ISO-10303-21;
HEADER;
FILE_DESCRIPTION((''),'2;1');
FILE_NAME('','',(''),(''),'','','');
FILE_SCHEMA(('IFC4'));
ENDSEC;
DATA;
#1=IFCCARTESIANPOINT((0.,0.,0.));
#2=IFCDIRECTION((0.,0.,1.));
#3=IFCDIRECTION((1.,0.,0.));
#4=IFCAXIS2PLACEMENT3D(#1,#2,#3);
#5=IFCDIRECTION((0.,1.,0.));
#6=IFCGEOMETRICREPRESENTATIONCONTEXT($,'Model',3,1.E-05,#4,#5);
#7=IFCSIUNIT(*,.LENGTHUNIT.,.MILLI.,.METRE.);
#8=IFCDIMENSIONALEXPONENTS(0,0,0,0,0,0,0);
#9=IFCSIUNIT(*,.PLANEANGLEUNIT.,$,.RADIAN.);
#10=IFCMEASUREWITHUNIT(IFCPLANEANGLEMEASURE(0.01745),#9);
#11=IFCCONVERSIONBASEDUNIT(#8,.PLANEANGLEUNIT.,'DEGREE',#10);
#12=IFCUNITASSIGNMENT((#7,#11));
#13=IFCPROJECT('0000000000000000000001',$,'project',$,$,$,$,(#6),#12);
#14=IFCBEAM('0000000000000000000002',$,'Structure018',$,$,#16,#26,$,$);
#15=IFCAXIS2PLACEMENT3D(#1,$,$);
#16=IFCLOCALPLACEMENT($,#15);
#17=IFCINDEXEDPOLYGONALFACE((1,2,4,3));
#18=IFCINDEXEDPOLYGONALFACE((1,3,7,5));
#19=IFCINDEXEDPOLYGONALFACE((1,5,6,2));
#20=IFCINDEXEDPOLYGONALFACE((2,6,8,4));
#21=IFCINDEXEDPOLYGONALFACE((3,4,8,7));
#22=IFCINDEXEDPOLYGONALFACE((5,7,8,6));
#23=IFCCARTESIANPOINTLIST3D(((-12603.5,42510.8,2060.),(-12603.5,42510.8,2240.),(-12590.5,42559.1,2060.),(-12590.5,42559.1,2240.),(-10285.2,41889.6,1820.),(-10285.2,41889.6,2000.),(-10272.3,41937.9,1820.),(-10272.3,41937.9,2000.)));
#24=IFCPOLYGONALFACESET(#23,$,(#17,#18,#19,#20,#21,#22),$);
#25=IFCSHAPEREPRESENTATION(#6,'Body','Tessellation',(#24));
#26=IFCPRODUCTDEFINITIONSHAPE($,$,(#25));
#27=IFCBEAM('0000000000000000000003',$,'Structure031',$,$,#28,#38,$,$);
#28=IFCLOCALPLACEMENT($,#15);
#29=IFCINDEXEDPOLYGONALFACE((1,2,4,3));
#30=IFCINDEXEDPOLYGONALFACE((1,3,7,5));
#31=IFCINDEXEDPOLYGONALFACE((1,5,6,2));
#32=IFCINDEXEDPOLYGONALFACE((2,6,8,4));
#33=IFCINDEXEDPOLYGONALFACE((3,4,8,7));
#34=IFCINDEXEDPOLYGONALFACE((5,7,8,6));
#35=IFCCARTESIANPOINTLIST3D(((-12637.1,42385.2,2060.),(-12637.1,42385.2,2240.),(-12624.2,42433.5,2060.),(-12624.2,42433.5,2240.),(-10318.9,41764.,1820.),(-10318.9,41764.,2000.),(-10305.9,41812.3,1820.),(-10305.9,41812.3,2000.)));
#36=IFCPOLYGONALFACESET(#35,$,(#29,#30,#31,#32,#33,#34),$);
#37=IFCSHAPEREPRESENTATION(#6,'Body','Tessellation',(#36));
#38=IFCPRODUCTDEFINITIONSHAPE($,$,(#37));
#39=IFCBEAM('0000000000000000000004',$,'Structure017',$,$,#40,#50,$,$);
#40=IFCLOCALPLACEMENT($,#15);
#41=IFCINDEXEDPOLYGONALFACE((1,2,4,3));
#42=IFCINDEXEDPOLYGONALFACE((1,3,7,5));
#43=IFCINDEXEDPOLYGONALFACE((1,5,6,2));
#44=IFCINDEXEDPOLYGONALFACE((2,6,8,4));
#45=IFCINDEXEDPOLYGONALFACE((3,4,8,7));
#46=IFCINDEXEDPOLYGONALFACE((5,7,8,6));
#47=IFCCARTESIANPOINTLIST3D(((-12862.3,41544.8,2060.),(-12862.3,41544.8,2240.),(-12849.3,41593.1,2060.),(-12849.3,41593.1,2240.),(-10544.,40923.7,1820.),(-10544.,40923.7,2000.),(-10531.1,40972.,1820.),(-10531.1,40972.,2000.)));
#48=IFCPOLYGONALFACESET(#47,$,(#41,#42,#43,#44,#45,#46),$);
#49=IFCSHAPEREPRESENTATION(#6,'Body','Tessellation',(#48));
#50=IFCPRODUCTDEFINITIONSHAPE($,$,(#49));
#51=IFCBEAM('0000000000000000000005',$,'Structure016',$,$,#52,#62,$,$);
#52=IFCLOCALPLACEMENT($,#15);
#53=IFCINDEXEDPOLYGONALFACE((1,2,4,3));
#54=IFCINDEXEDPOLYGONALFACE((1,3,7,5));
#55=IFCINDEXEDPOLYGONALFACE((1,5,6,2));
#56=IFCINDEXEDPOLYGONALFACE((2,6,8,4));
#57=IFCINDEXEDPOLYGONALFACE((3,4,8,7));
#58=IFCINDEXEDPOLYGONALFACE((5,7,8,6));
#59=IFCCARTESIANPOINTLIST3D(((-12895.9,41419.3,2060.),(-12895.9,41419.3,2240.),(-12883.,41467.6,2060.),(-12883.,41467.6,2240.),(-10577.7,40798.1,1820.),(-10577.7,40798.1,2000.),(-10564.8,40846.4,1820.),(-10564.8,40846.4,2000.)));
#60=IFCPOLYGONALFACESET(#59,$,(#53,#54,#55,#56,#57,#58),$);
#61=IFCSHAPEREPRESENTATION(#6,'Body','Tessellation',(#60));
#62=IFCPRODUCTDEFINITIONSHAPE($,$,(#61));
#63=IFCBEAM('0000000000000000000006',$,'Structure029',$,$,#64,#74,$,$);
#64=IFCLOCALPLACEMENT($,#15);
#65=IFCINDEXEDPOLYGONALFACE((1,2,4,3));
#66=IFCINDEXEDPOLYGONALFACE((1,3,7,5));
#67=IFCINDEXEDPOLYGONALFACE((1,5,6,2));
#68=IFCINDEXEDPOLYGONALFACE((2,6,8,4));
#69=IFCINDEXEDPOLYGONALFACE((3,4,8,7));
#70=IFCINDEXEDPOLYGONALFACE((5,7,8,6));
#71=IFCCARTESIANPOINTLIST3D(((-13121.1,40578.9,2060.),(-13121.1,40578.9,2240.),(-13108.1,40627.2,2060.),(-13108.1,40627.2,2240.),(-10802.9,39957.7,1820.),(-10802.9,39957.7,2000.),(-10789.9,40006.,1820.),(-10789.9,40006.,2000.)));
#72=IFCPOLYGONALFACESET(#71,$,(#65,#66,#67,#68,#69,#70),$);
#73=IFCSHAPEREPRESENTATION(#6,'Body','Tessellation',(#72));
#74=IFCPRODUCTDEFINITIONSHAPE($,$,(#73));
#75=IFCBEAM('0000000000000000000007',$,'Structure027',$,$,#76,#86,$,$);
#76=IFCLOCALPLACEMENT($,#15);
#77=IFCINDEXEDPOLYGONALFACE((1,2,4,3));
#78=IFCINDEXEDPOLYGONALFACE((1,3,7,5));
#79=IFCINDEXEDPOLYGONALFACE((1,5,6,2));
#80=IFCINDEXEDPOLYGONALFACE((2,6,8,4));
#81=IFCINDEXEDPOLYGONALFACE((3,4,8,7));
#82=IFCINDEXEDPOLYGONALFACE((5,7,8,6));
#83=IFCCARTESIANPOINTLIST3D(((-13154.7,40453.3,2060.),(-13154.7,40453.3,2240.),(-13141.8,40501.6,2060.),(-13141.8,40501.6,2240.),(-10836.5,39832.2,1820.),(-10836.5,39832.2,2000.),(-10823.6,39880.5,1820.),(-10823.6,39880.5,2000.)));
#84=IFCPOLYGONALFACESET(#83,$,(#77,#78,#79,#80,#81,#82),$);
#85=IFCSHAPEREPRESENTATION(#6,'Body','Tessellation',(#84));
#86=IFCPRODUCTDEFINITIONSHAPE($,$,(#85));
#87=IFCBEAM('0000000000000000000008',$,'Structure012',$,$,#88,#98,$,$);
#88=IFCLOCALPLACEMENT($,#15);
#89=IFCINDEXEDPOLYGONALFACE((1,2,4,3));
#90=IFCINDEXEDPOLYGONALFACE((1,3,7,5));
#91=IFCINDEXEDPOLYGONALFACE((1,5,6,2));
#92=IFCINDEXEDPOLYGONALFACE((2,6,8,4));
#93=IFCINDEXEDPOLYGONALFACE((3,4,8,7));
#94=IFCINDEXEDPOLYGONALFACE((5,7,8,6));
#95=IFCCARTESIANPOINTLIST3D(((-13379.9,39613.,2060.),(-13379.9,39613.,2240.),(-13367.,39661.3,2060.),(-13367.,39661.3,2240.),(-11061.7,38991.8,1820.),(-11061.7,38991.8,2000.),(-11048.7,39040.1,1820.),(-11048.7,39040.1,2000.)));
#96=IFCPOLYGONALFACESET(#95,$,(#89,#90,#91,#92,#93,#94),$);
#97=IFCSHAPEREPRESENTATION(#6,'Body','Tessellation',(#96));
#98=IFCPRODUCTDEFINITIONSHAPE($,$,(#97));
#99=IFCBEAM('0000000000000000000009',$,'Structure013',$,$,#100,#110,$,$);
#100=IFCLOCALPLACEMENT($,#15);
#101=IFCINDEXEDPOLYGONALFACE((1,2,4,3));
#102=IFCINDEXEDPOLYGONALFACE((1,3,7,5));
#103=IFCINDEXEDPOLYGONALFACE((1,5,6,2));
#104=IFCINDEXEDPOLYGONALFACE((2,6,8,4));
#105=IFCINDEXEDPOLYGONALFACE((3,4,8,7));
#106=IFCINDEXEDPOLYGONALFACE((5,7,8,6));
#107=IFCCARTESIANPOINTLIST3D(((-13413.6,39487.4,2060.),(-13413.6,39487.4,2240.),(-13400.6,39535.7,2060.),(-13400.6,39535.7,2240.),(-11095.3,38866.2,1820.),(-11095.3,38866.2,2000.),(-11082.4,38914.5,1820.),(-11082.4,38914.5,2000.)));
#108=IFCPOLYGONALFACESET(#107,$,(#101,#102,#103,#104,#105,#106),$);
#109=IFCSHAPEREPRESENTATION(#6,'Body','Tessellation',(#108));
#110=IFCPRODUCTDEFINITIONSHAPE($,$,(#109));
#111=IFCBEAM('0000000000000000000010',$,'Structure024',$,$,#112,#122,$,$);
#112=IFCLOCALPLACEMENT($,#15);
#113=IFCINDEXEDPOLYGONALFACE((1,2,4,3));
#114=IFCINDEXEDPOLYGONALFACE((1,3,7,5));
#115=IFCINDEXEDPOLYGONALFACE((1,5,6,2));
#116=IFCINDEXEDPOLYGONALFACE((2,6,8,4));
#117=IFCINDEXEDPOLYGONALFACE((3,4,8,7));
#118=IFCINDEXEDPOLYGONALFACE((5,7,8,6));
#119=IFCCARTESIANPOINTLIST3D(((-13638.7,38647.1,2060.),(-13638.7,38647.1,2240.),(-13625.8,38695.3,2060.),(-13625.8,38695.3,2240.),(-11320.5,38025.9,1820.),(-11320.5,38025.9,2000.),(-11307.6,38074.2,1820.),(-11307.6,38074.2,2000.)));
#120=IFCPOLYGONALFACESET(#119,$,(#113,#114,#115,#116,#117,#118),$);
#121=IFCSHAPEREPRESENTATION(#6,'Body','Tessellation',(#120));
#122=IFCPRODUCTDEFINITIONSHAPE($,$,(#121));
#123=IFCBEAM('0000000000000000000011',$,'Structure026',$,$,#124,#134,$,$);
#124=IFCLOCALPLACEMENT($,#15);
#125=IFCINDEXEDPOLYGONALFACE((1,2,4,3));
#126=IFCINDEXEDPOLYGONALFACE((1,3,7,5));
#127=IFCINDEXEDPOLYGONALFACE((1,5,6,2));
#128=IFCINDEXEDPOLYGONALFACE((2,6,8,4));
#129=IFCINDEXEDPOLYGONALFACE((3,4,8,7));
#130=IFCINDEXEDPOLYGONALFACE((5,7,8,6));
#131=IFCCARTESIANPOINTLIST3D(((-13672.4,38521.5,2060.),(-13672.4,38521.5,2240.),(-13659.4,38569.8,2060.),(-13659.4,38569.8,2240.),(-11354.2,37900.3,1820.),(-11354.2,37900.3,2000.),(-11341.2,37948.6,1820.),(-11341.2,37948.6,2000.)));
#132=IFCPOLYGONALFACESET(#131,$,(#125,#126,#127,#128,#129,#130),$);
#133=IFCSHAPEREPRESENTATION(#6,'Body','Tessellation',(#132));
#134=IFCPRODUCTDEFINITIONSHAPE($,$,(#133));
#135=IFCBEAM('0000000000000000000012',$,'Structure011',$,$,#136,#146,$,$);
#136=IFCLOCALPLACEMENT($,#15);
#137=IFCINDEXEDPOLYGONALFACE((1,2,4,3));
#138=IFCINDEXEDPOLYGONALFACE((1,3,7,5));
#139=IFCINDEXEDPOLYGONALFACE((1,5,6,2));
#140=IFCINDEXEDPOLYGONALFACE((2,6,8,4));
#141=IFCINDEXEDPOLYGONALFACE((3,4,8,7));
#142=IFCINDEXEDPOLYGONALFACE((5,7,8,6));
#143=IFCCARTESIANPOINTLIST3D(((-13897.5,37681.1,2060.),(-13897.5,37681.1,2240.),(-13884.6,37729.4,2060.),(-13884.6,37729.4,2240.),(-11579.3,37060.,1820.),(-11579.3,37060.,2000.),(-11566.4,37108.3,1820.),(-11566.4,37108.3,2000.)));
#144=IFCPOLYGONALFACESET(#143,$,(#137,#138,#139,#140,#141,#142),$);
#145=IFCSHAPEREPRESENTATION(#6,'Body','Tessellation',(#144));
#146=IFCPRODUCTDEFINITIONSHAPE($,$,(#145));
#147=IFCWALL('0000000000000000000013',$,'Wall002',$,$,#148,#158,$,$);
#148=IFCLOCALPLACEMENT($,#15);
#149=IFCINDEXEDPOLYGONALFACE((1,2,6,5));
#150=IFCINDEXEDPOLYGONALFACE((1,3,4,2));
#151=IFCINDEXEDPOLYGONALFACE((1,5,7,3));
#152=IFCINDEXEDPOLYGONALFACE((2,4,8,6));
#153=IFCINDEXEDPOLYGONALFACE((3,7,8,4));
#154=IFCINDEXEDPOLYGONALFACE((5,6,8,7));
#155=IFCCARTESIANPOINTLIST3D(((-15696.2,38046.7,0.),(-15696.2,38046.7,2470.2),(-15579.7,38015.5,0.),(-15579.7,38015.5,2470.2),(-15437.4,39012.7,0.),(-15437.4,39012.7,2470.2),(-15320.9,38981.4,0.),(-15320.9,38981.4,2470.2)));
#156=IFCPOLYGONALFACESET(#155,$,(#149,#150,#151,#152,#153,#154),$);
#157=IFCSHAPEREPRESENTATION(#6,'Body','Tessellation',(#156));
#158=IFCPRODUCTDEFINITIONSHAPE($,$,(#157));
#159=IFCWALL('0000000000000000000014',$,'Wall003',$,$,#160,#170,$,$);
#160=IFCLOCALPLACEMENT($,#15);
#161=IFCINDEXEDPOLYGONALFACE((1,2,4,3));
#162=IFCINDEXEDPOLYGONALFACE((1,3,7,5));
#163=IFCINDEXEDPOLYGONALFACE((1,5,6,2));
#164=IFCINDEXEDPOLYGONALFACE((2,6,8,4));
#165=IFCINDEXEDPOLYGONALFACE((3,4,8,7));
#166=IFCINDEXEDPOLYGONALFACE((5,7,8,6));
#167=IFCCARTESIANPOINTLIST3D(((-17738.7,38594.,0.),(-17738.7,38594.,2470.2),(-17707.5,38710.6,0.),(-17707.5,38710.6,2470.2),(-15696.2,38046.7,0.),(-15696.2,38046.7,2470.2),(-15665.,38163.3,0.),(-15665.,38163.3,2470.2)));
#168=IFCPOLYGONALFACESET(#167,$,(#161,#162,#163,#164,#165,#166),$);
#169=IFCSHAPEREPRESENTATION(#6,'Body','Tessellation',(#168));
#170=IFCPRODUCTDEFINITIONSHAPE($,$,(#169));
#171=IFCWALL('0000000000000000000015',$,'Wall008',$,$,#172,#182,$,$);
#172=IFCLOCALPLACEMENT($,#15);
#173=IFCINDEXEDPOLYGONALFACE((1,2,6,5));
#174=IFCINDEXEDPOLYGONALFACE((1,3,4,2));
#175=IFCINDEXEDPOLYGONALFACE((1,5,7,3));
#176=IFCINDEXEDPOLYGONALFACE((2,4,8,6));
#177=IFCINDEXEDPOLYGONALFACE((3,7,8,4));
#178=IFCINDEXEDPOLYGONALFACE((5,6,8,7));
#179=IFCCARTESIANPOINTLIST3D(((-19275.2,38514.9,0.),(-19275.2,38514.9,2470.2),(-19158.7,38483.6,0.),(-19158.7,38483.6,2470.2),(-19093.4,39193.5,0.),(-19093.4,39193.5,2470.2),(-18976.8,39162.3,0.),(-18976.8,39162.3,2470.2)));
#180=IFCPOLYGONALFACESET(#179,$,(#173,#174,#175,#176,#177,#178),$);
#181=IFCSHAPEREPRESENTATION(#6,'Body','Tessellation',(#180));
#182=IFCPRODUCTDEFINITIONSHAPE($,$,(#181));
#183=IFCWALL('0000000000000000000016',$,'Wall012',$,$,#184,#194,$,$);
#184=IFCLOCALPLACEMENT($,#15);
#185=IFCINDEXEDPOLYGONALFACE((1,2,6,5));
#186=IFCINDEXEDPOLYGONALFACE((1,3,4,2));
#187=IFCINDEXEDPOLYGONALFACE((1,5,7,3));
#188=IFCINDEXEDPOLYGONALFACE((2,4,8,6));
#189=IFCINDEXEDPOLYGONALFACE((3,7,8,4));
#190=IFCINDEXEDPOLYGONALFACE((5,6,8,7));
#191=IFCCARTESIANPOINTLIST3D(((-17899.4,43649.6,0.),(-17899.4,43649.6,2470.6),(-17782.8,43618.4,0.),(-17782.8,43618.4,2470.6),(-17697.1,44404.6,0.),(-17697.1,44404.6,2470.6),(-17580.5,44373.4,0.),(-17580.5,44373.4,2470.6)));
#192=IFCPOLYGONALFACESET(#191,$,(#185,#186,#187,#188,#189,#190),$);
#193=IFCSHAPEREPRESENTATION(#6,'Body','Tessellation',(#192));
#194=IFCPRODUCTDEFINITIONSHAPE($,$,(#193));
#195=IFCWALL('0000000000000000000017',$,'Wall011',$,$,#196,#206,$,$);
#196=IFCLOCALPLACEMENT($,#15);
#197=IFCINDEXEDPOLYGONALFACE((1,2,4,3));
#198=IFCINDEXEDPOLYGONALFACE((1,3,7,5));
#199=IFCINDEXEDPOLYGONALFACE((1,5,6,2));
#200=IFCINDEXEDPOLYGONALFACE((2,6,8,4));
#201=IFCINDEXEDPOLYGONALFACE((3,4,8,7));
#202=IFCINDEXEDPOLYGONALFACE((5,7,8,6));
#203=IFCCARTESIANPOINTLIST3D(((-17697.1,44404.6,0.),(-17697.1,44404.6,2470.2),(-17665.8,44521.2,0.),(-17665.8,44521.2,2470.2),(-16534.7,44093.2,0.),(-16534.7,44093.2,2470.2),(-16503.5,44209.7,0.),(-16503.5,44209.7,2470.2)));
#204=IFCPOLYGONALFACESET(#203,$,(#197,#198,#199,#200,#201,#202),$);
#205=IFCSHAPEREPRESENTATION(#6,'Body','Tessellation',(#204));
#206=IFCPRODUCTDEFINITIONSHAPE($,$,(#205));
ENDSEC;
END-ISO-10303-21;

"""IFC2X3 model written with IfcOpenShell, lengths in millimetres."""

from ifc_helpers import new_model, entity, si_unit, converted_unit, direction, frame, origin_with_axes, place, context, project, polyline, outline, extrude, element, save


model = new_model("IFC2X3")

# Units and contexts
model_context = context("Model", 3, precision=1e-05, world=origin_with_axes(), true_north=direction((0.0, 1.0, 0.0)))
ifc_project = project(units=[si_unit("LENGTHUNIT", "METRE", prefix="MILLI"), converted_unit("PLANEANGLEUNIT", "DEGREE", entity("IfcPlaneAngleMeasure", 0.01745), si_unit("PLANEANGLEUNIT", "RADIAN"), dimensions=[0, 0, 0, 0, 0, 0, 0])], contexts=[model_context])

# Beams
beam_1_placement = place(None, origin_with_axes())
element("IfcBeam", 1, at=beam_1_placement, Name="Structure018", context=model_context, shape_type="SweptSolid", body=[
    extrude(outline(polyline([(-90.0, -25.0), (90.0, -25.0), (90.0, 25.0), (-90.0, 25.0), (-90.0, -25.0)])), frame((-12597.0, 42534.9, 2150.0), z_axis=(0.965926, -0.258818, 0.0), x_axis=(0.0, 0.0, -1.0)), (0.099504, 0.0, 0.995037), 2412.0),
])
beam_2_placement = place(None, origin_with_axes())
element("IfcBeam", 2, at=beam_2_placement, Name="Structure031", context=model_context, shape_type="SweptSolid", body=[
    extrude(outline(polyline([(-90.0, -25.0), (90.0, -25.0), (90.0, 25.0), (-90.0, 25.0), (-90.0, -25.0)])), frame((-12630.6, 42409.3, 2150.0), z_axis=(0.965926, -0.258818, 0.0), x_axis=(0.0, 0.0, -1.0)), (0.099504, 0.0, 0.995037), 2412.0),
])
beam_3_placement = place(None, origin_with_axes())
element("IfcBeam", 3, at=beam_3_placement, Name="Structure017", context=model_context, shape_type="SweptSolid", body=[
    extrude(outline(polyline([(-90.0, -25.0), (90.0, -25.0), (90.0, 25.0), (-90.0, 25.0), (-90.0, -25.0)])), frame((-12855.8, 41569.0, 2150.0), z_axis=(0.965926, -0.258818, 0.0), x_axis=(0.0, 0.0, -1.0)), (0.099504, 0.0, 0.995037), 2412.0),
])
beam_4_placement = place(None, origin_with_axes())
element("IfcBeam", 4, at=beam_4_placement, Name="Structure016", context=model_context, shape_type="SweptSolid", body=[
    extrude(outline(polyline([(-90.0, -25.0), (90.0, -25.0), (90.0, 25.0), (-90.0, 25.0), (-90.0, -25.0)])), frame((-12889.4, 41443.4, 2150.0), z_axis=(0.965926, -0.258818, 0.0), x_axis=(0.0, 0.0, -1.0)), (0.099504, 0.0, 0.995037), 2412.0),
])
beam_5_placement = place(None, origin_with_axes())
element("IfcBeam", 5, at=beam_5_placement, Name="Structure029", context=model_context, shape_type="SweptSolid", body=[
    extrude(outline(polyline([(-90.0, -25.0), (90.0, -25.0), (90.0, 25.0), (-90.0, 25.0), (-90.0, -25.0)])), frame((-13114.6, 40603.1, 2150.0), z_axis=(0.965926, -0.258818, 0.0), x_axis=(0.0, 0.0, -1.0)), (0.099504, 0.0, 0.995037), 2412.0),
])
beam_6_placement = place(None, origin_with_axes())
element("IfcBeam", 6, at=beam_6_placement, Name="Structure027", context=model_context, shape_type="SweptSolid", body=[
    extrude(outline(polyline([(-90.0, -25.0), (90.0, -25.0), (90.0, 25.0), (-90.0, 25.0), (-90.0, -25.0)])), frame((-13148.3, 40477.5, 2150.0), z_axis=(0.965926, -0.258818, 0.0), x_axis=(0.0, 0.0, -1.0)), (0.099504, 0.0, 0.995037), 2412.0),
])
beam_7_placement = place(None, origin_with_axes())
element("IfcBeam", 7, at=beam_7_placement, Name="Structure012", context=model_context, shape_type="SweptSolid", body=[
    extrude(outline(polyline([(-90.0, -25.0), (90.0, -25.0), (90.0, 25.0), (-90.0, 25.0), (-90.0, -25.0)])), frame((-13373.4, 39637.1, 2150.0), z_axis=(0.965926, -0.258818, 0.0), x_axis=(0.0, 0.0, -1.0)), (0.099504, 0.0, 0.995037), 2412.0),
])
beam_8_placement = place(None, origin_with_axes())
element("IfcBeam", 8, at=beam_8_placement, Name="Structure013", context=model_context, shape_type="SweptSolid", body=[
    extrude(outline(polyline([(-90.0, -25.0), (90.0, -25.0), (90.0, 25.0), (-90.0, 25.0), (-90.0, -25.0)])), frame((-13407.1, 39511.6, 2150.0), z_axis=(0.965926, -0.258818, 0.0), x_axis=(0.0, 0.0, -1.0)), (0.099504, 0.0, 0.995037), 2412.0),
])
beam_9_placement = place(None, origin_with_axes())
element("IfcBeam", 9, at=beam_9_placement, Name="Structure024", context=model_context, shape_type="SweptSolid", body=[
    extrude(outline(polyline([(-90.0, -25.0), (90.0, -25.0), (90.0, 25.0), (-90.0, 25.0), (-90.0, -25.0)])), frame((-13632.3, 38671.2, 2150.0), z_axis=(0.965926, -0.258818, 0.0), x_axis=(0.0, 0.0, -1.0)), (0.099504, 0.0, 0.995037), 2412.0),
])
beam_10_placement = place(None, origin_with_axes())
element("IfcBeam", 10, at=beam_10_placement, Name="Structure026", context=model_context, shape_type="SweptSolid", body=[
    extrude(outline(polyline([(-90.0, -25.0), (90.0, -25.0), (90.0, 25.0), (-90.0, 25.0), (-90.0, -25.0)])), frame((-13665.9, 38545.6, 2150.0), z_axis=(0.965926, -0.258818, 0.0), x_axis=(0.0, 0.0, -1.0)), (0.099504, 0.0, 0.995037), 2412.0),
])
beam_11_placement = place(None, origin_with_axes())
element("IfcBeam", 11, at=beam_11_placement, Name="Structure011", context=model_context, shape_type="SweptSolid", body=[
    extrude(outline(polyline([(-90.0, -25.0), (90.0, -25.0), (90.0, 25.0), (-90.0, 25.0), (-90.0, -25.0)])), frame((-13891.1, 37705.3, 2150.0), z_axis=(0.965926, -0.258818, 0.0), x_axis=(0.0, 0.0, -1.0)), (0.099504, 0.0, 0.995037), 2412.0),
])

# Walls
wall_1_placement = place(None, origin_with_axes())
element("IfcWall", 12, at=wall_1_placement, Name="Wall002", context=model_context, shape_type="SweptSolid", body=[
    extrude(outline(polyline([(0.0, 0.0), (-120.7, 0.0), (-120.6, 1000.0), (0.0, 1000.0), (0.0, 0.0)])), frame((-15579.7, 38015.5, 0.0), z_axis=(0.0, 0.0, 1.0), x_axis=(0.965926, -0.258819, 0.0)), (0.0, 0.0, 1.0), 2470.2),
])
wall_2_placement = place(None, origin_with_axes())
element("IfcWall", 13, at=wall_2_placement, Name="Wall003", context=model_context, shape_type="SweptSolid", body=[
    extrude(outline(polyline([(-15696.2, 38046.7), (-17738.7, 38594.0), (-17707.5, 38710.6), (-15665.0, 38163.3), (-15696.2, 38046.7)])), origin_with_axes(), (0.0, 0.0, 1.0), 2470.2),
])
wall_3_placement = place(None, origin_with_axes())
element("IfcWall", 14, at=wall_3_placement, Name="Wall008", context=model_context, shape_type="SweptSolid", body=[
    extrude(outline(polyline([(-18976.8, 39162.3), (-19158.7, 38483.6), (-19275.2, 38514.9), (-19093.4, 39193.5), (-18976.8, 39162.3)])), origin_with_axes(), (0.0, 0.0, 1.0), 2470.2),
])
wall_4_placement = place(None, origin_with_axes())
element("IfcWall", 15, at=wall_4_placement, Name="Wall012", context=model_context, shape_type="SweptSolid", body=[
    extrude(outline(polyline([(-17782.8, 43618.4), (-17580.5, 44373.4), (-17697.1, 44404.6), (-17899.4, 43649.6), (-17782.8, 43618.4)])), origin_with_axes(), (0.0, 0.0, 1.0), 2470.6),
])
wall_5_placement = place(None, origin_with_axes())
element("IfcWall", 16, at=wall_5_placement, Name="Wall011", context=model_context, shape_type="SweptSolid", body=[
    extrude(outline(polyline([(-17697.1, 44404.6), (-16534.7, 44093.2), (-16503.5, 44209.7), (-17665.8, 44521.2), (-17697.1, 44404.6)])), origin_with_axes(), (0.0, 0.0, 1.0), 2470.2),
])

save(model, "model.ifc")
